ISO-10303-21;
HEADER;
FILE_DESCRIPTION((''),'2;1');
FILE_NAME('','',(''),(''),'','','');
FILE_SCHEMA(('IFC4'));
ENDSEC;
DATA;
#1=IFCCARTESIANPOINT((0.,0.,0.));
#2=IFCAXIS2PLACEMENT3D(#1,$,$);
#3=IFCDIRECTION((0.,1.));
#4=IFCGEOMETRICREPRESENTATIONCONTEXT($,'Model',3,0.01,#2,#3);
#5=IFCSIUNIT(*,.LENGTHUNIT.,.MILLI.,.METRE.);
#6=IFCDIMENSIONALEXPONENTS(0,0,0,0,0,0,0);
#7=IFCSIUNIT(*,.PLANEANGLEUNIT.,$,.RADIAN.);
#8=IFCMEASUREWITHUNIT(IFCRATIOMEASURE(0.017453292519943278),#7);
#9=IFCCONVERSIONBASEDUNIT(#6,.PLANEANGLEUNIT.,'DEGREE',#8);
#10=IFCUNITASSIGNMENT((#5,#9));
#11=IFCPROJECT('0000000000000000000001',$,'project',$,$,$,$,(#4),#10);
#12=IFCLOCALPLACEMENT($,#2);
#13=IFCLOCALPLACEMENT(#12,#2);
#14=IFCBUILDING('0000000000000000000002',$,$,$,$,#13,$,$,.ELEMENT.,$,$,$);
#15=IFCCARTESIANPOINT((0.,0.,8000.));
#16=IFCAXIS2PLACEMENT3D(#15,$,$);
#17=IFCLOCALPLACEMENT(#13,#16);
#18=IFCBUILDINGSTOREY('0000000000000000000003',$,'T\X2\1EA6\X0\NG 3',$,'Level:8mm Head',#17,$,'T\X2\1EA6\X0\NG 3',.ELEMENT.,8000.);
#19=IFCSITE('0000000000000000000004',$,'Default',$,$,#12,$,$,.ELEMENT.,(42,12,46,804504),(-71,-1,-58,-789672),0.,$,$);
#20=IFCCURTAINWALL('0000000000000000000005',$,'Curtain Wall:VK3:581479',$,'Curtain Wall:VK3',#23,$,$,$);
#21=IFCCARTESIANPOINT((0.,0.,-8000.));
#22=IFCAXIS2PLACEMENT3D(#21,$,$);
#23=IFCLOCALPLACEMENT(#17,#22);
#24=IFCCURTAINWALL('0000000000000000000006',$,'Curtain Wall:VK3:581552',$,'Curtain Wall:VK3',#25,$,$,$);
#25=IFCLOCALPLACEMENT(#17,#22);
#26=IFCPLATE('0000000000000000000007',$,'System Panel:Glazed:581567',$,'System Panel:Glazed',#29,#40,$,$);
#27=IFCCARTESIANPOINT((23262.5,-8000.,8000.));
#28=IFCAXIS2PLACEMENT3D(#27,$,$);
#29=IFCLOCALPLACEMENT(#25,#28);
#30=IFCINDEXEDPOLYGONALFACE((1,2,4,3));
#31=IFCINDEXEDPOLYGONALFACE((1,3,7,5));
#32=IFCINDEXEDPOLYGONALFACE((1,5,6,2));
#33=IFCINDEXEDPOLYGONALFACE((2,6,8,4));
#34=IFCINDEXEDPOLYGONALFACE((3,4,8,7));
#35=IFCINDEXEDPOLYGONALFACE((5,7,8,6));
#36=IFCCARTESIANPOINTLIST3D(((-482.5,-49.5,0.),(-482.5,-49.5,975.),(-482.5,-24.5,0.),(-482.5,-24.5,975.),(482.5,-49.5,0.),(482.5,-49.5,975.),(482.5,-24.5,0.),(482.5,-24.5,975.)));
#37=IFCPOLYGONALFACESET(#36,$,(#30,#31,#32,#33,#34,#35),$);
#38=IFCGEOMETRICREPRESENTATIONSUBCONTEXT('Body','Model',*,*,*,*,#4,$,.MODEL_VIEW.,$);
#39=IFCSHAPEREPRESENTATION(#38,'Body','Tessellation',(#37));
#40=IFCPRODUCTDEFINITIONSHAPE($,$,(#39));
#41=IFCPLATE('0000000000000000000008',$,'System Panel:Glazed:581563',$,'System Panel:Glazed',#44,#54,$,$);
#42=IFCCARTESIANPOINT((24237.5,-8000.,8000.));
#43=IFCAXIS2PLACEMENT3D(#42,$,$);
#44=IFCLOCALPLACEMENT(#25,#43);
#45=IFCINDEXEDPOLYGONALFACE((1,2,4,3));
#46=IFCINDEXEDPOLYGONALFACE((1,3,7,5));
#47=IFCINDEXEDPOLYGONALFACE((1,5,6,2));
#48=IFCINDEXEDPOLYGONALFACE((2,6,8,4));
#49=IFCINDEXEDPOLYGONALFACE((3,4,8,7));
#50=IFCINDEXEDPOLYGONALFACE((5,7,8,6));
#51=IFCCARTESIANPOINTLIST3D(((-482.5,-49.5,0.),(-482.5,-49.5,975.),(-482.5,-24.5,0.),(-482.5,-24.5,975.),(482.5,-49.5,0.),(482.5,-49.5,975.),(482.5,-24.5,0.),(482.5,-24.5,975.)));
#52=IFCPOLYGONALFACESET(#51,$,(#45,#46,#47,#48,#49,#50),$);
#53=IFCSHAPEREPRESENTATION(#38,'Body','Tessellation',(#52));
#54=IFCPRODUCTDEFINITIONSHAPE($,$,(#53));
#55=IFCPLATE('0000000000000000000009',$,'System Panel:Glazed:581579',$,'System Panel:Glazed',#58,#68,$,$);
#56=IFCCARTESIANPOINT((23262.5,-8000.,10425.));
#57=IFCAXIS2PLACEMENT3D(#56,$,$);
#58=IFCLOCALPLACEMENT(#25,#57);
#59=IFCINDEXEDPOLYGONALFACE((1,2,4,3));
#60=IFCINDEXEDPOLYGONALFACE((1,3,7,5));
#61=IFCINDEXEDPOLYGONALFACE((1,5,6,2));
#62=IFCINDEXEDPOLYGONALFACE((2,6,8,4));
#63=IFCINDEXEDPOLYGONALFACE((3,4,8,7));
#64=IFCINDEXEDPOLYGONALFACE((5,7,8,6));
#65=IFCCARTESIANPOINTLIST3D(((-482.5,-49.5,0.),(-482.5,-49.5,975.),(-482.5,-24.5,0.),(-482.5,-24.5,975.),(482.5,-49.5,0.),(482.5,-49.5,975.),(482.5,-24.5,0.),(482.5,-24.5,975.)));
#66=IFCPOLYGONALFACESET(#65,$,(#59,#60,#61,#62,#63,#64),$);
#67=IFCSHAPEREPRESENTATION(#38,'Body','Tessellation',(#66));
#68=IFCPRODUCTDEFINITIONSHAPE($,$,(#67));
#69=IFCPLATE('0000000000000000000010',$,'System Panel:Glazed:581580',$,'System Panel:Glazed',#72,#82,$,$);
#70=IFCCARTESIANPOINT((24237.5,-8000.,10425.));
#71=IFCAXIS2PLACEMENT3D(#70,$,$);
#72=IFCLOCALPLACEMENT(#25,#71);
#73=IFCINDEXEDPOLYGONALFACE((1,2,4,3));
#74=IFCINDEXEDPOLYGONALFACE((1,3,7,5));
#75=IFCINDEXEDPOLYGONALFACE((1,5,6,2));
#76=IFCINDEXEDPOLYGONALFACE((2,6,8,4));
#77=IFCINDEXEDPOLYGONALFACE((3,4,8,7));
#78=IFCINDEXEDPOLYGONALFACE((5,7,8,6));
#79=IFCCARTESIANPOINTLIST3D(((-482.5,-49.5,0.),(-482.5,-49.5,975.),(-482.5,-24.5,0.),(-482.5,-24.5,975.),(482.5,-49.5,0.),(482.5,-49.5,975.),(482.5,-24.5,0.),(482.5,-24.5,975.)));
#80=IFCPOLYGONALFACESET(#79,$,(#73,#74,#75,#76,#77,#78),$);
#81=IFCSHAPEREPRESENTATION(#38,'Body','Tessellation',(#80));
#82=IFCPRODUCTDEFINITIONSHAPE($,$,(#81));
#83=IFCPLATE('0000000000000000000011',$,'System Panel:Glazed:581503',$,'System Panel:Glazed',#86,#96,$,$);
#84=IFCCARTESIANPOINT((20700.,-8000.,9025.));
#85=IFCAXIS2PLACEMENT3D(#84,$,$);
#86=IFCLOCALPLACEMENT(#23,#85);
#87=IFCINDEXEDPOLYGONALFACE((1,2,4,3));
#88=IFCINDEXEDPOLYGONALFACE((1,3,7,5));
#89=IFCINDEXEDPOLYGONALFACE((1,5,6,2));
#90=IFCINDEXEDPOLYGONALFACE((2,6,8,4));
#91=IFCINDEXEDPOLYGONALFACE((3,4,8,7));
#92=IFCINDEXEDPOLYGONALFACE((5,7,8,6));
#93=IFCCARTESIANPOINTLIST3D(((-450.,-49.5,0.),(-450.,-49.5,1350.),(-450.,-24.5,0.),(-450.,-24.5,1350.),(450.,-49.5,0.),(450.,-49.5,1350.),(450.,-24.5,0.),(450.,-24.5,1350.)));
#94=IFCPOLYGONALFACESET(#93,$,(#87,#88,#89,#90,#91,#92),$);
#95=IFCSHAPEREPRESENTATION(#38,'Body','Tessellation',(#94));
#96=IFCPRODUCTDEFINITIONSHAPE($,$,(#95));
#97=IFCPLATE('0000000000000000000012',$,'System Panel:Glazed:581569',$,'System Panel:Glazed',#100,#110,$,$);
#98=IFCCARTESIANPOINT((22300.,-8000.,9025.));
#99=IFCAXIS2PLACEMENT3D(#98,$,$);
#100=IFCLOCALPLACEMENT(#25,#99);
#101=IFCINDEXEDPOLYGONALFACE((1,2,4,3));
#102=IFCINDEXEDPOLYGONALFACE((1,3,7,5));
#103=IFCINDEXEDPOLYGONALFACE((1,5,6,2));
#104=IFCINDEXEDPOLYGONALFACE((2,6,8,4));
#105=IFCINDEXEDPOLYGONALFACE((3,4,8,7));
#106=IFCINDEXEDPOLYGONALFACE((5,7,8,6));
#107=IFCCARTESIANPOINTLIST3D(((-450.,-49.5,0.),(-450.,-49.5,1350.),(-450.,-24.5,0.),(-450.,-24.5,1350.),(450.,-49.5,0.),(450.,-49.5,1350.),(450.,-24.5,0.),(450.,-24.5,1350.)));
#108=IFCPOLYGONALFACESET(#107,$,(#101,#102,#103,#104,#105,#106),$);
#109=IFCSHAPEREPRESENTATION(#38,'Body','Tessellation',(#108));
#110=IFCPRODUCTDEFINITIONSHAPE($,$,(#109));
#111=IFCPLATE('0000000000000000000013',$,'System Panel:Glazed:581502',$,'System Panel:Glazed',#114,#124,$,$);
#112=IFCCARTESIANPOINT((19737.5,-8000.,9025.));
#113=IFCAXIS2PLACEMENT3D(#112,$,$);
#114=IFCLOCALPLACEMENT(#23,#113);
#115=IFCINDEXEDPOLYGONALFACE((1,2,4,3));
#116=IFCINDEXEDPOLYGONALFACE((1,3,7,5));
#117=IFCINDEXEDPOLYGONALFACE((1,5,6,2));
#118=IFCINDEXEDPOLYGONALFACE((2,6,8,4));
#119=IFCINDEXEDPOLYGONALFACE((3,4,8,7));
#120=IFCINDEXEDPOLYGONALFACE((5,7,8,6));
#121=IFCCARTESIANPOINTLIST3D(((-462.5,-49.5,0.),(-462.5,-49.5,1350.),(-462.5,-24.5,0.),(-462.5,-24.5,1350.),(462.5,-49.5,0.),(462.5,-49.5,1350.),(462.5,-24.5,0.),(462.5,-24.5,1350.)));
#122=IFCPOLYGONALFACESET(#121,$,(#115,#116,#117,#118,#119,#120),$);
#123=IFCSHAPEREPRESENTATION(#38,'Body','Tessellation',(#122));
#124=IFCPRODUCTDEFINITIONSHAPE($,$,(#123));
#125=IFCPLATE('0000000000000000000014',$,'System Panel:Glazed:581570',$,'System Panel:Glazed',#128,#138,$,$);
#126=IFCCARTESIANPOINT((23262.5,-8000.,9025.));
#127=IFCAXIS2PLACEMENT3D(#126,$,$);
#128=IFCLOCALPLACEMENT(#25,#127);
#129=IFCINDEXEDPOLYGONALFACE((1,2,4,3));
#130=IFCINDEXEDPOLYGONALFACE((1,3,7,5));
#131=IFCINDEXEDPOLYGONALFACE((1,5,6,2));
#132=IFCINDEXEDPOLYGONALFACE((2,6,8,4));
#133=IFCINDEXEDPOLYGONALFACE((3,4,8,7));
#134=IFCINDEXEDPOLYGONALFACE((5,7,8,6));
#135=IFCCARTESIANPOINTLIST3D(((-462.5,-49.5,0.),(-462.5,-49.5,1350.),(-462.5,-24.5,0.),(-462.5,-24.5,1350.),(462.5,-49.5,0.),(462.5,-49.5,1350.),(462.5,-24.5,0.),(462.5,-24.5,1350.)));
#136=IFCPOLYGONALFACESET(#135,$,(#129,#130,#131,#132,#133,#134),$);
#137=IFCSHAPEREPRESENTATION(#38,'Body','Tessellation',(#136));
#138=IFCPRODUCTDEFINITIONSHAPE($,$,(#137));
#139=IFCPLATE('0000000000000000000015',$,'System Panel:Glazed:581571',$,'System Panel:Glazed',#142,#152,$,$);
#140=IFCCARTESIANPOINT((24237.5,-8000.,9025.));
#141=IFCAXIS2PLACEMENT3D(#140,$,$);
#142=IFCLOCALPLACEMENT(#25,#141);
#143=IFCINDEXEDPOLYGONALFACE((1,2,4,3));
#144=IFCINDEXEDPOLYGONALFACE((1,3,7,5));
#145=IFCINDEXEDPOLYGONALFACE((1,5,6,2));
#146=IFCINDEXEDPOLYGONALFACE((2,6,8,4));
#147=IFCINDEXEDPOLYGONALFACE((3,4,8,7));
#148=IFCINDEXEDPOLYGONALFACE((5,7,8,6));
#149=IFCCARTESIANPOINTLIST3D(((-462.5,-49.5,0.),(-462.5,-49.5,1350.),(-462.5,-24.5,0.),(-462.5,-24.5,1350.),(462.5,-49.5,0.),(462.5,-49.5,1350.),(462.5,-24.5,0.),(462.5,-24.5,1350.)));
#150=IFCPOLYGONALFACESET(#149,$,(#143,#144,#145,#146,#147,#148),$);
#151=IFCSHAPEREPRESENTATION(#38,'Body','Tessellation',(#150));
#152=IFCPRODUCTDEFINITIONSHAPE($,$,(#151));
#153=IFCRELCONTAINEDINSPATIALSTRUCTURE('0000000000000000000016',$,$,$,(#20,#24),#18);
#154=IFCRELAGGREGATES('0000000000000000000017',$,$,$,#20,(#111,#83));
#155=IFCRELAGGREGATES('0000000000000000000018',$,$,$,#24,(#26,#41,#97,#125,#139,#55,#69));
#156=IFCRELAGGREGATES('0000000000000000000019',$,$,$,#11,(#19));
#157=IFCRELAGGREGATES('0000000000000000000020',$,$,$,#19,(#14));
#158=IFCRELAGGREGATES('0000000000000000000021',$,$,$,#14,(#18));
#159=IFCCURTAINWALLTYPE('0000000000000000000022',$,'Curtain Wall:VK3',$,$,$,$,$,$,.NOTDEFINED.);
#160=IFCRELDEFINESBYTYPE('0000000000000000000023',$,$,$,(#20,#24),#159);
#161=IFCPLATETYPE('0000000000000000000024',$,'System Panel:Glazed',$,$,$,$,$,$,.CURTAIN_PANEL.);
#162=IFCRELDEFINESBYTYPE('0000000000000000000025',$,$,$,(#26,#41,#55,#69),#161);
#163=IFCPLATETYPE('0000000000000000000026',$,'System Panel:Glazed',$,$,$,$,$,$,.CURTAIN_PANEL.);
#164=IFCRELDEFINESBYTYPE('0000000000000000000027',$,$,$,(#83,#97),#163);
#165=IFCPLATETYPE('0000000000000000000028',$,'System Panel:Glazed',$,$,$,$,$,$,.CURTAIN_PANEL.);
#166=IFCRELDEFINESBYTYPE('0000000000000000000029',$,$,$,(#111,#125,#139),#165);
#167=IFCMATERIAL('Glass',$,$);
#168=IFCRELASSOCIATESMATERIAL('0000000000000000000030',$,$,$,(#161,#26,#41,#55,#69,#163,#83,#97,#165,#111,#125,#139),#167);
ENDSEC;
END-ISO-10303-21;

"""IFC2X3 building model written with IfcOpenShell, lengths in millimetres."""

from ifc_helpers import new_model, entity, si_unit, converted_unit, direction, frame, frame_2d, origin, place, context, subcontext, project, spatial, rectangle, extrude, source, transform, mapped, material, type_object, type_shapes, element, aggregate, save


model = new_model("IFC2X3")

# Units and contexts
model_context = context("Model", 3, precision=0.01, world=origin(), true_north=direction((0.0, 1.0)))
body_context = subcontext(model_context, "Body", "Model", "MODEL_VIEW")
ifc_project = project(units=[si_unit("LENGTHUNIT", "METRE", prefix="MILLI"), converted_unit("PLANEANGLEUNIT", "DEGREE", entity("IfcRatioMeasure", 0.017453292519943278), si_unit("PLANEANGLEUNIT", "RADIAN"), dimensions=[0, 0, 0, 0, 0, 0, 0])], contexts=[model_context])

# Site, building, storey
site_placement = place(None, origin())
site = spatial("IfcSite", under=ifc_project, at=site_placement, Name="Default", CompositionType="ELEMENT", RefLatitude=(42, 12, 46, 804504), RefLongitude=(-71, -1, -58, -789672), RefElevation=0.0)
building_placement = place(site_placement, origin())
building = spatial("IfcBuilding", under=site, at=building_placement, CompositionType="ELEMENT")
storey_placement = place(building_placement, frame((0.0, 0.0, 8000.0)))
storey = spatial("IfcBuildingStorey", under=building, at=storey_placement, Name="TẦNG 3", ObjectType="Level:8mm Head", LongName="TẦNG 3", CompositionType="ELEMENT", Elevation=8000.0)

# Curtain wall
curtain_wall_type = type_object("IfcCurtainWallType", Name="Curtain Wall:VK3", PredefinedType="NOTDEFINED")
curtain_wall_1_placement = place(storey_placement, frame((0.0, 0.0, -8000.0)))
curtain_wall_1 = element("IfcCurtainWall", 1, at=curtain_wall_1_placement, inside=storey, type_object=curtain_wall_type, Name="Curtain Wall:VK3:581479", ObjectType="Curtain Wall:VK3")

# Curtain wall
curtain_wall_2_placement = place(storey_placement, frame((0.0, 0.0, -8000.0)))
curtain_wall_2 = element("IfcCurtainWall", 2, at=curtain_wall_2_placement, inside=storey, type_object=curtain_wall_type, Name="Curtain Wall:VK3:581552", ObjectType="Curtain Wall:VK3")

# Plates
ifc_material_1 = material(Name="Glass")
plate_type_1 = type_object("IfcPlateType", Name="System Panel:Glazed", PredefinedType="CURTAIN_PANEL", material=ifc_material_1)
shared_shape_1 = source(origin(), body_context, "Body", "SweptSolid", [
    extrude(rectangle(XDim=25.0, YDim=965.0, at=frame_2d((0.0, 0.0), x_axis=(1.0, 0.0))), frame((0.0, -37.0, 0.0), z_axis=(0.0, 0.0, 1.0), x_axis=(0.0, 1.0, 0.0)), (0.0, 0.0, 1.0), 975.0),
])
type_shapes(plate_type_1, [shared_shape_1])
plate_1_placement = place(curtain_wall_2_placement, frame((23262.5, -8000.0, 8000.0)))
plate_1 = element("IfcPlate", 3, at=plate_1_placement, type_object=plate_type_1, material=ifc_material_1, Name="System Panel:Glazed:581567", ObjectType="System Panel:Glazed", context=body_context, shape_type="MappedRepresentation", body=[
    mapped(shared_shape_1, transform((0.0, 0.0, 0.0), scale=1.0)),
])
plate_2_placement = place(curtain_wall_2_placement, frame((24237.5, -8000.0, 8000.0)))
plate_2 = element("IfcPlate", 4, at=plate_2_placement, type_object=plate_type_1, material=ifc_material_1, Name="System Panel:Glazed:581563", ObjectType="System Panel:Glazed", context=body_context, shape_type="MappedRepresentation", body=[
    mapped(shared_shape_1, transform((0.0, 0.0, 0.0), scale=1.0)),
])
plate_3_placement = place(curtain_wall_2_placement, frame((23262.5, -8000.0, 10425.0)))
plate_3 = element("IfcPlate", 5, at=plate_3_placement, type_object=plate_type_1, material=ifc_material_1, Name="System Panel:Glazed:581579", ObjectType="System Panel:Glazed", context=body_context, shape_type="MappedRepresentation", body=[
    mapped(shared_shape_1, transform((0.0, 0.0, 0.0), scale=1.0)),
])
plate_4_placement = place(curtain_wall_2_placement, frame((24237.5, -8000.0, 10425.0)))
plate_4 = element("IfcPlate", 6, at=plate_4_placement, type_object=plate_type_1, material=ifc_material_1, Name="System Panel:Glazed:581580", ObjectType="System Panel:Glazed", context=body_context, shape_type="MappedRepresentation", body=[
    mapped(shared_shape_1, transform((0.0, 0.0, 0.0), scale=1.0)),
])
plate_type_2 = type_object("IfcPlateType", Name="System Panel:Glazed", PredefinedType="CURTAIN_PANEL", material=ifc_material_1)
shared_shape_2 = source(origin(), body_context, "Body", "SweptSolid", [
    extrude(rectangle(XDim=25.0, YDim=900.0, at=frame_2d((0.0, 0.0), x_axis=(1.0, 0.0))), frame((0.0, -37.0, 0.0), z_axis=(0.0, 0.0, 1.0), x_axis=(0.0, 1.0, 0.0)), (0.0, 0.0, 1.0), 1350.0),
])
type_shapes(plate_type_2, [shared_shape_2])
plate_5_placement = place(curtain_wall_1_placement, frame((20700.0, -8000.0, 9025.0)))
plate_5 = element("IfcPlate", 7, at=plate_5_placement, type_object=plate_type_2, material=ifc_material_1, Name="System Panel:Glazed:581503", ObjectType="System Panel:Glazed", context=body_context, shape_type="MappedRepresentation", body=[
    mapped(shared_shape_2, transform((0.0, 0.0, 0.0), scale=1.0)),
])
plate_6_placement = place(curtain_wall_2_placement, frame((22300.0, -8000.0, 9025.0)))
plate_6 = element("IfcPlate", 8, at=plate_6_placement, type_object=plate_type_2, material=ifc_material_1, Name="System Panel:Glazed:581569", ObjectType="System Panel:Glazed", context=body_context, shape_type="MappedRepresentation", body=[
    mapped(shared_shape_2, transform((0.0, 0.0, 0.0), scale=1.0)),
])
plate_type_3 = type_object("IfcPlateType", Name="System Panel:Glazed", PredefinedType="CURTAIN_PANEL", material=ifc_material_1)
shared_shape_3 = source(origin(), body_context, "Body", "SweptSolid", [
    extrude(rectangle(XDim=25.0, YDim=925.0, at=frame_2d((0.0, 0.0), x_axis=(1.0, 0.0))), frame((0.0, -37.0, 0.0), z_axis=(0.0, 0.0, 1.0), x_axis=(0.0, 1.0, 0.0)), (0.0, 0.0, 1.0), 1350.0),
])
type_shapes(plate_type_3, [shared_shape_3])
plate_7_placement = place(curtain_wall_1_placement, frame((19737.5, -8000.0, 9025.0)))
plate_7 = element("IfcPlate", 9, at=plate_7_placement, type_object=plate_type_3, material=ifc_material_1, Name="System Panel:Glazed:581502", ObjectType="System Panel:Glazed", context=body_context, shape_type="MappedRepresentation", body=[
    mapped(shared_shape_3, transform((0.0, 0.0, 0.0), scale=1.0)),
])
aggregate(curtain_wall_1, [plate_7, plate_5])
plate_8_placement = place(curtain_wall_2_placement, frame((23262.5, -8000.0, 9025.0)))
plate_8 = element("IfcPlate", 10, at=plate_8_placement, type_object=plate_type_3, material=ifc_material_1, Name="System Panel:Glazed:581570", ObjectType="System Panel:Glazed", context=body_context, shape_type="MappedRepresentation", body=[
    mapped(shared_shape_3, transform((0.0, 0.0, 0.0), scale=1.0)),
])
plate_9_placement = place(curtain_wall_2_placement, frame((24237.5, -8000.0, 9025.0)))
plate_9 = element("IfcPlate", 11, at=plate_9_placement, type_object=plate_type_3, material=ifc_material_1, Name="System Panel:Glazed:581571", ObjectType="System Panel:Glazed", context=body_context, shape_type="MappedRepresentation", body=[
    mapped(shared_shape_3, transform((0.0, 0.0, 0.0), scale=1.0)),
])
aggregate(curtain_wall_2, [plate_1, plate_2, plate_6, plate_8, plate_9, plate_3, plate_4])

save(model, "model.ifc")
